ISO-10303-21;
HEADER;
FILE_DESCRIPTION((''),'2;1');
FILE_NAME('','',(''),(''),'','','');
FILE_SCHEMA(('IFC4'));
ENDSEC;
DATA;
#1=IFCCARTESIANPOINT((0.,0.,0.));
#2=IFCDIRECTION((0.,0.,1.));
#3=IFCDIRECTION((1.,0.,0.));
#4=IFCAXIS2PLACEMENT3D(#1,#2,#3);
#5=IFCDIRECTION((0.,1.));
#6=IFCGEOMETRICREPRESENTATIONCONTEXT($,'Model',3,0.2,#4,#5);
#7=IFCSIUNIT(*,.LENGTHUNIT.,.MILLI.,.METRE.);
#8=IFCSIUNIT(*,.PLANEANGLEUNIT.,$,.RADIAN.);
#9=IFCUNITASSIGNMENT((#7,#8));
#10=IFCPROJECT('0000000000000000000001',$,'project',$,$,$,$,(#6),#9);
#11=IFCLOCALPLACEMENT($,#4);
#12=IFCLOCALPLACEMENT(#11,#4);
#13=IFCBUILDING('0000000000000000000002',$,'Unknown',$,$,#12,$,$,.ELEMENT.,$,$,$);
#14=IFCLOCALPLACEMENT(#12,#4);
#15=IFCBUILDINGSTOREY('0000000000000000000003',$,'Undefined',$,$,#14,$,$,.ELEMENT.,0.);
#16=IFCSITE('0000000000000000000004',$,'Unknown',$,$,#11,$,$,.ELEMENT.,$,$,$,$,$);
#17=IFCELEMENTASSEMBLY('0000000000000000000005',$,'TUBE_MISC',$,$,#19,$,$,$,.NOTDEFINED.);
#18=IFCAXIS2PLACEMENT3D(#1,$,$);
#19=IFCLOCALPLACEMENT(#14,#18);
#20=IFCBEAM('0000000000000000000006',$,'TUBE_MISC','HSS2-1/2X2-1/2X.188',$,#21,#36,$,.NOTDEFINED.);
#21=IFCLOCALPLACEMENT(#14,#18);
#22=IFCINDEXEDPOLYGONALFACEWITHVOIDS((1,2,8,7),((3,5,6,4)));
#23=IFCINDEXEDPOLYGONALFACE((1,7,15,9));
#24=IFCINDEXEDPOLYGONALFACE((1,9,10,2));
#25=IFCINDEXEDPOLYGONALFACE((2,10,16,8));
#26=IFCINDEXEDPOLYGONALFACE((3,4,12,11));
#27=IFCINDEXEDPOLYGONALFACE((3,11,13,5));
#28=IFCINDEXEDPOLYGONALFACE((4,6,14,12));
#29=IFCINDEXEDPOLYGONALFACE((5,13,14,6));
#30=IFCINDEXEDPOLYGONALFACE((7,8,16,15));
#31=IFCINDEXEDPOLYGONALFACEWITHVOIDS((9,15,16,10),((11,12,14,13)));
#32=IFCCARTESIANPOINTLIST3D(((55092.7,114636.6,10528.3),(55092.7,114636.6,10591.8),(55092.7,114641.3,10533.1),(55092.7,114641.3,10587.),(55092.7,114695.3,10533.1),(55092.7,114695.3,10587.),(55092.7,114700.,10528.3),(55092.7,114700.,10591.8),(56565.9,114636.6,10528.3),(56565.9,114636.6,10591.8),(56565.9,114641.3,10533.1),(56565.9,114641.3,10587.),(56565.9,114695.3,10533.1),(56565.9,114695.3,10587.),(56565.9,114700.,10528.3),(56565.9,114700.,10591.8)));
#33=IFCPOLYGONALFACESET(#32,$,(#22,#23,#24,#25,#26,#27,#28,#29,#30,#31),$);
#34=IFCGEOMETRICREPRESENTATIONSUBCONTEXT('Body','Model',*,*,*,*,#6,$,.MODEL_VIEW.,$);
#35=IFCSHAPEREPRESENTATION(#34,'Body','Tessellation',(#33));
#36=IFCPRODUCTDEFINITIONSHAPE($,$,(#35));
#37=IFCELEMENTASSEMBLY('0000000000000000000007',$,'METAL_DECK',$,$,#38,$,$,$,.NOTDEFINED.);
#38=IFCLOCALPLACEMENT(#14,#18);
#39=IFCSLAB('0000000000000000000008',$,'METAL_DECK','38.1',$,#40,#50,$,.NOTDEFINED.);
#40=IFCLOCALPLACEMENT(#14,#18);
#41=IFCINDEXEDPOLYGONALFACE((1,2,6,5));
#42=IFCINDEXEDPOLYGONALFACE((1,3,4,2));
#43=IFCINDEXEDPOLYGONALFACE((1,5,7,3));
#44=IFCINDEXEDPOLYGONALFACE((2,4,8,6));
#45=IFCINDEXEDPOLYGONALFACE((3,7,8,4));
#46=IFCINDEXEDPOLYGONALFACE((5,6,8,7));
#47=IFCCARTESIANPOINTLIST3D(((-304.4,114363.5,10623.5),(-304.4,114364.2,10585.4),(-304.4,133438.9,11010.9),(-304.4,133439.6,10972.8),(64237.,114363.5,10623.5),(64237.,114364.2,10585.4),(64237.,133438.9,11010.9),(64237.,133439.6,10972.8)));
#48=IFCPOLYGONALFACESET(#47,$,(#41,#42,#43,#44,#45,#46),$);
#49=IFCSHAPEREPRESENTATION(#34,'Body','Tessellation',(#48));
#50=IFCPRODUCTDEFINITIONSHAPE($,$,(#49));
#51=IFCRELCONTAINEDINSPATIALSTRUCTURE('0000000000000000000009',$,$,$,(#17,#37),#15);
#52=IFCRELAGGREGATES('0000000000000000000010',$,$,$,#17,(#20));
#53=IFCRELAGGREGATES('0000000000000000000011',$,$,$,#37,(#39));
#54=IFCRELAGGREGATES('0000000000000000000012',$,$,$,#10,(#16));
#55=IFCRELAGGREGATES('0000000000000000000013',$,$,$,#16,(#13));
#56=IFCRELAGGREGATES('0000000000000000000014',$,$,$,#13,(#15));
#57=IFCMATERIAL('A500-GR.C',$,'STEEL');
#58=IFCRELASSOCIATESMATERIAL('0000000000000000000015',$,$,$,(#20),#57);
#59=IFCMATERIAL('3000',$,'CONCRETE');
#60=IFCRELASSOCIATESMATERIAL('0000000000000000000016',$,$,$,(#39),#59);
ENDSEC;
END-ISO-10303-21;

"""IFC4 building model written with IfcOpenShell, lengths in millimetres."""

from ifc_helpers import new_model, si_unit, direction, frame, origin_with_axes, place, context, subcontext, project, spatial, line, indexed_curve, outline, extrude, material, element, aggregate, save


model = new_model("IFC4")

# Units and contexts
model_context = context("Model", 3, precision=0.2, world=origin_with_axes(), true_north=direction((0.0, 1.0)))
body_context = subcontext(model_context, "Body", "Model", "MODEL_VIEW")
ifc_project = project(units=[si_unit("LENGTHUNIT", "METRE", prefix="MILLI"), si_unit("PLANEANGLEUNIT", "RADIAN")], contexts=[model_context])

# Site, building, storey
site_placement = place(None, origin_with_axes())
site = spatial("IfcSite", under=ifc_project, at=site_placement, Name="Unknown", CompositionType="ELEMENT")
building_placement = place(site_placement, origin_with_axes())
building = spatial("IfcBuilding", under=site, at=building_placement, Name="Unknown", CompositionType="ELEMENT")
storey_placement = place(building_placement, origin_with_axes())
storey = spatial("IfcBuildingStorey", under=building, at=storey_placement, Name="Undefined", CompositionType="ELEMENT", Elevation=0.0)

# Shared definitions
ifc_material_1 = material(Name="A500-GR.C", Category="STEEL")

# Element assembly, beam
assembly_1_placement = place(storey_placement, frame((55092.7, 114668.3, 10560.0), z_axis=(0.0, -1.0, 0.0), x_axis=(1.0, 0.0, 0.0)))
assembly_1 = element("IfcElementAssembly", 1, at=assembly_1_placement, inside=storey, Name="TUBE_MISC", PredefinedType="NOTDEFINED")
beam_1_placement = place(assembly_1_placement, origin_with_axes())
beam_1 = element("IfcBeam", 2, at=beam_1_placement, material=ifc_material_1, Name="TUBE_MISC", Description="HSS2-1/2X2-1/2X.188", PredefinedType="NOTDEFINED", context=body_context, shape_type="SolidModel", body=[
    extrude(outline(indexed_curve([(-31.8, -31.8), (31.8, -31.8), (31.8, 31.8), (-31.8, 31.8)], segments=[line(1, 2, 3, 4, 1)]), holes=[indexed_curve([(-27.0, -27.0), (-27.0, 27.0), (27.0, 27.0), (27.0, -27.0)], segments=[line(1, 2, 3, 4, 1)])]), frame((0.0, 0.0, 0.0), z_axis=(-1.0, 0.0, 0.0), x_axis=(0.0, 0.0, 1.0)), (0.0, 0.0, -1.0), 1473.2),
])
aggregate(assembly_1, [beam_1])

# Element assembly, slab
assembly_2_placement = place(storey_placement, frame((64237.0, 114363.9, 10604.5), z_axis=(0.0, -0.020303, 0.999794), x_axis=(0.0, 0.999794, 0.020303)))
assembly_2 = element("IfcElementAssembly", 3, at=assembly_2_placement, inside=storey, Name="METAL_DECK", PredefinedType="NOTDEFINED")
ifc_material_2 = material(Name="3000", Category="CONCRETE")
slab_placement = place(assembly_2_placement, origin_with_axes())
slab = element("IfcSlab", 4, at=slab_placement, material=ifc_material_2, Name="METAL_DECK", Description="38.1", PredefinedType="NOTDEFINED", context=body_context, shape_type="SolidModel", body=[
    extrude(outline(indexed_curve([(0.0, 0.0), (19079.3, 0.0), (19079.3, 64541.4), (0.0, 64541.4)], segments=[line(1, 2, 3, 4, 1)])), frame((0.0, 0.0, 19.1), z_axis=(0.0, 0.0, 1.0), x_axis=(1.0, 0.0, 0.0)), (0.0, 0.0, -1.0), 38.1),
])
aggregate(assembly_2, [slab])

save(model, "model.ifc")
